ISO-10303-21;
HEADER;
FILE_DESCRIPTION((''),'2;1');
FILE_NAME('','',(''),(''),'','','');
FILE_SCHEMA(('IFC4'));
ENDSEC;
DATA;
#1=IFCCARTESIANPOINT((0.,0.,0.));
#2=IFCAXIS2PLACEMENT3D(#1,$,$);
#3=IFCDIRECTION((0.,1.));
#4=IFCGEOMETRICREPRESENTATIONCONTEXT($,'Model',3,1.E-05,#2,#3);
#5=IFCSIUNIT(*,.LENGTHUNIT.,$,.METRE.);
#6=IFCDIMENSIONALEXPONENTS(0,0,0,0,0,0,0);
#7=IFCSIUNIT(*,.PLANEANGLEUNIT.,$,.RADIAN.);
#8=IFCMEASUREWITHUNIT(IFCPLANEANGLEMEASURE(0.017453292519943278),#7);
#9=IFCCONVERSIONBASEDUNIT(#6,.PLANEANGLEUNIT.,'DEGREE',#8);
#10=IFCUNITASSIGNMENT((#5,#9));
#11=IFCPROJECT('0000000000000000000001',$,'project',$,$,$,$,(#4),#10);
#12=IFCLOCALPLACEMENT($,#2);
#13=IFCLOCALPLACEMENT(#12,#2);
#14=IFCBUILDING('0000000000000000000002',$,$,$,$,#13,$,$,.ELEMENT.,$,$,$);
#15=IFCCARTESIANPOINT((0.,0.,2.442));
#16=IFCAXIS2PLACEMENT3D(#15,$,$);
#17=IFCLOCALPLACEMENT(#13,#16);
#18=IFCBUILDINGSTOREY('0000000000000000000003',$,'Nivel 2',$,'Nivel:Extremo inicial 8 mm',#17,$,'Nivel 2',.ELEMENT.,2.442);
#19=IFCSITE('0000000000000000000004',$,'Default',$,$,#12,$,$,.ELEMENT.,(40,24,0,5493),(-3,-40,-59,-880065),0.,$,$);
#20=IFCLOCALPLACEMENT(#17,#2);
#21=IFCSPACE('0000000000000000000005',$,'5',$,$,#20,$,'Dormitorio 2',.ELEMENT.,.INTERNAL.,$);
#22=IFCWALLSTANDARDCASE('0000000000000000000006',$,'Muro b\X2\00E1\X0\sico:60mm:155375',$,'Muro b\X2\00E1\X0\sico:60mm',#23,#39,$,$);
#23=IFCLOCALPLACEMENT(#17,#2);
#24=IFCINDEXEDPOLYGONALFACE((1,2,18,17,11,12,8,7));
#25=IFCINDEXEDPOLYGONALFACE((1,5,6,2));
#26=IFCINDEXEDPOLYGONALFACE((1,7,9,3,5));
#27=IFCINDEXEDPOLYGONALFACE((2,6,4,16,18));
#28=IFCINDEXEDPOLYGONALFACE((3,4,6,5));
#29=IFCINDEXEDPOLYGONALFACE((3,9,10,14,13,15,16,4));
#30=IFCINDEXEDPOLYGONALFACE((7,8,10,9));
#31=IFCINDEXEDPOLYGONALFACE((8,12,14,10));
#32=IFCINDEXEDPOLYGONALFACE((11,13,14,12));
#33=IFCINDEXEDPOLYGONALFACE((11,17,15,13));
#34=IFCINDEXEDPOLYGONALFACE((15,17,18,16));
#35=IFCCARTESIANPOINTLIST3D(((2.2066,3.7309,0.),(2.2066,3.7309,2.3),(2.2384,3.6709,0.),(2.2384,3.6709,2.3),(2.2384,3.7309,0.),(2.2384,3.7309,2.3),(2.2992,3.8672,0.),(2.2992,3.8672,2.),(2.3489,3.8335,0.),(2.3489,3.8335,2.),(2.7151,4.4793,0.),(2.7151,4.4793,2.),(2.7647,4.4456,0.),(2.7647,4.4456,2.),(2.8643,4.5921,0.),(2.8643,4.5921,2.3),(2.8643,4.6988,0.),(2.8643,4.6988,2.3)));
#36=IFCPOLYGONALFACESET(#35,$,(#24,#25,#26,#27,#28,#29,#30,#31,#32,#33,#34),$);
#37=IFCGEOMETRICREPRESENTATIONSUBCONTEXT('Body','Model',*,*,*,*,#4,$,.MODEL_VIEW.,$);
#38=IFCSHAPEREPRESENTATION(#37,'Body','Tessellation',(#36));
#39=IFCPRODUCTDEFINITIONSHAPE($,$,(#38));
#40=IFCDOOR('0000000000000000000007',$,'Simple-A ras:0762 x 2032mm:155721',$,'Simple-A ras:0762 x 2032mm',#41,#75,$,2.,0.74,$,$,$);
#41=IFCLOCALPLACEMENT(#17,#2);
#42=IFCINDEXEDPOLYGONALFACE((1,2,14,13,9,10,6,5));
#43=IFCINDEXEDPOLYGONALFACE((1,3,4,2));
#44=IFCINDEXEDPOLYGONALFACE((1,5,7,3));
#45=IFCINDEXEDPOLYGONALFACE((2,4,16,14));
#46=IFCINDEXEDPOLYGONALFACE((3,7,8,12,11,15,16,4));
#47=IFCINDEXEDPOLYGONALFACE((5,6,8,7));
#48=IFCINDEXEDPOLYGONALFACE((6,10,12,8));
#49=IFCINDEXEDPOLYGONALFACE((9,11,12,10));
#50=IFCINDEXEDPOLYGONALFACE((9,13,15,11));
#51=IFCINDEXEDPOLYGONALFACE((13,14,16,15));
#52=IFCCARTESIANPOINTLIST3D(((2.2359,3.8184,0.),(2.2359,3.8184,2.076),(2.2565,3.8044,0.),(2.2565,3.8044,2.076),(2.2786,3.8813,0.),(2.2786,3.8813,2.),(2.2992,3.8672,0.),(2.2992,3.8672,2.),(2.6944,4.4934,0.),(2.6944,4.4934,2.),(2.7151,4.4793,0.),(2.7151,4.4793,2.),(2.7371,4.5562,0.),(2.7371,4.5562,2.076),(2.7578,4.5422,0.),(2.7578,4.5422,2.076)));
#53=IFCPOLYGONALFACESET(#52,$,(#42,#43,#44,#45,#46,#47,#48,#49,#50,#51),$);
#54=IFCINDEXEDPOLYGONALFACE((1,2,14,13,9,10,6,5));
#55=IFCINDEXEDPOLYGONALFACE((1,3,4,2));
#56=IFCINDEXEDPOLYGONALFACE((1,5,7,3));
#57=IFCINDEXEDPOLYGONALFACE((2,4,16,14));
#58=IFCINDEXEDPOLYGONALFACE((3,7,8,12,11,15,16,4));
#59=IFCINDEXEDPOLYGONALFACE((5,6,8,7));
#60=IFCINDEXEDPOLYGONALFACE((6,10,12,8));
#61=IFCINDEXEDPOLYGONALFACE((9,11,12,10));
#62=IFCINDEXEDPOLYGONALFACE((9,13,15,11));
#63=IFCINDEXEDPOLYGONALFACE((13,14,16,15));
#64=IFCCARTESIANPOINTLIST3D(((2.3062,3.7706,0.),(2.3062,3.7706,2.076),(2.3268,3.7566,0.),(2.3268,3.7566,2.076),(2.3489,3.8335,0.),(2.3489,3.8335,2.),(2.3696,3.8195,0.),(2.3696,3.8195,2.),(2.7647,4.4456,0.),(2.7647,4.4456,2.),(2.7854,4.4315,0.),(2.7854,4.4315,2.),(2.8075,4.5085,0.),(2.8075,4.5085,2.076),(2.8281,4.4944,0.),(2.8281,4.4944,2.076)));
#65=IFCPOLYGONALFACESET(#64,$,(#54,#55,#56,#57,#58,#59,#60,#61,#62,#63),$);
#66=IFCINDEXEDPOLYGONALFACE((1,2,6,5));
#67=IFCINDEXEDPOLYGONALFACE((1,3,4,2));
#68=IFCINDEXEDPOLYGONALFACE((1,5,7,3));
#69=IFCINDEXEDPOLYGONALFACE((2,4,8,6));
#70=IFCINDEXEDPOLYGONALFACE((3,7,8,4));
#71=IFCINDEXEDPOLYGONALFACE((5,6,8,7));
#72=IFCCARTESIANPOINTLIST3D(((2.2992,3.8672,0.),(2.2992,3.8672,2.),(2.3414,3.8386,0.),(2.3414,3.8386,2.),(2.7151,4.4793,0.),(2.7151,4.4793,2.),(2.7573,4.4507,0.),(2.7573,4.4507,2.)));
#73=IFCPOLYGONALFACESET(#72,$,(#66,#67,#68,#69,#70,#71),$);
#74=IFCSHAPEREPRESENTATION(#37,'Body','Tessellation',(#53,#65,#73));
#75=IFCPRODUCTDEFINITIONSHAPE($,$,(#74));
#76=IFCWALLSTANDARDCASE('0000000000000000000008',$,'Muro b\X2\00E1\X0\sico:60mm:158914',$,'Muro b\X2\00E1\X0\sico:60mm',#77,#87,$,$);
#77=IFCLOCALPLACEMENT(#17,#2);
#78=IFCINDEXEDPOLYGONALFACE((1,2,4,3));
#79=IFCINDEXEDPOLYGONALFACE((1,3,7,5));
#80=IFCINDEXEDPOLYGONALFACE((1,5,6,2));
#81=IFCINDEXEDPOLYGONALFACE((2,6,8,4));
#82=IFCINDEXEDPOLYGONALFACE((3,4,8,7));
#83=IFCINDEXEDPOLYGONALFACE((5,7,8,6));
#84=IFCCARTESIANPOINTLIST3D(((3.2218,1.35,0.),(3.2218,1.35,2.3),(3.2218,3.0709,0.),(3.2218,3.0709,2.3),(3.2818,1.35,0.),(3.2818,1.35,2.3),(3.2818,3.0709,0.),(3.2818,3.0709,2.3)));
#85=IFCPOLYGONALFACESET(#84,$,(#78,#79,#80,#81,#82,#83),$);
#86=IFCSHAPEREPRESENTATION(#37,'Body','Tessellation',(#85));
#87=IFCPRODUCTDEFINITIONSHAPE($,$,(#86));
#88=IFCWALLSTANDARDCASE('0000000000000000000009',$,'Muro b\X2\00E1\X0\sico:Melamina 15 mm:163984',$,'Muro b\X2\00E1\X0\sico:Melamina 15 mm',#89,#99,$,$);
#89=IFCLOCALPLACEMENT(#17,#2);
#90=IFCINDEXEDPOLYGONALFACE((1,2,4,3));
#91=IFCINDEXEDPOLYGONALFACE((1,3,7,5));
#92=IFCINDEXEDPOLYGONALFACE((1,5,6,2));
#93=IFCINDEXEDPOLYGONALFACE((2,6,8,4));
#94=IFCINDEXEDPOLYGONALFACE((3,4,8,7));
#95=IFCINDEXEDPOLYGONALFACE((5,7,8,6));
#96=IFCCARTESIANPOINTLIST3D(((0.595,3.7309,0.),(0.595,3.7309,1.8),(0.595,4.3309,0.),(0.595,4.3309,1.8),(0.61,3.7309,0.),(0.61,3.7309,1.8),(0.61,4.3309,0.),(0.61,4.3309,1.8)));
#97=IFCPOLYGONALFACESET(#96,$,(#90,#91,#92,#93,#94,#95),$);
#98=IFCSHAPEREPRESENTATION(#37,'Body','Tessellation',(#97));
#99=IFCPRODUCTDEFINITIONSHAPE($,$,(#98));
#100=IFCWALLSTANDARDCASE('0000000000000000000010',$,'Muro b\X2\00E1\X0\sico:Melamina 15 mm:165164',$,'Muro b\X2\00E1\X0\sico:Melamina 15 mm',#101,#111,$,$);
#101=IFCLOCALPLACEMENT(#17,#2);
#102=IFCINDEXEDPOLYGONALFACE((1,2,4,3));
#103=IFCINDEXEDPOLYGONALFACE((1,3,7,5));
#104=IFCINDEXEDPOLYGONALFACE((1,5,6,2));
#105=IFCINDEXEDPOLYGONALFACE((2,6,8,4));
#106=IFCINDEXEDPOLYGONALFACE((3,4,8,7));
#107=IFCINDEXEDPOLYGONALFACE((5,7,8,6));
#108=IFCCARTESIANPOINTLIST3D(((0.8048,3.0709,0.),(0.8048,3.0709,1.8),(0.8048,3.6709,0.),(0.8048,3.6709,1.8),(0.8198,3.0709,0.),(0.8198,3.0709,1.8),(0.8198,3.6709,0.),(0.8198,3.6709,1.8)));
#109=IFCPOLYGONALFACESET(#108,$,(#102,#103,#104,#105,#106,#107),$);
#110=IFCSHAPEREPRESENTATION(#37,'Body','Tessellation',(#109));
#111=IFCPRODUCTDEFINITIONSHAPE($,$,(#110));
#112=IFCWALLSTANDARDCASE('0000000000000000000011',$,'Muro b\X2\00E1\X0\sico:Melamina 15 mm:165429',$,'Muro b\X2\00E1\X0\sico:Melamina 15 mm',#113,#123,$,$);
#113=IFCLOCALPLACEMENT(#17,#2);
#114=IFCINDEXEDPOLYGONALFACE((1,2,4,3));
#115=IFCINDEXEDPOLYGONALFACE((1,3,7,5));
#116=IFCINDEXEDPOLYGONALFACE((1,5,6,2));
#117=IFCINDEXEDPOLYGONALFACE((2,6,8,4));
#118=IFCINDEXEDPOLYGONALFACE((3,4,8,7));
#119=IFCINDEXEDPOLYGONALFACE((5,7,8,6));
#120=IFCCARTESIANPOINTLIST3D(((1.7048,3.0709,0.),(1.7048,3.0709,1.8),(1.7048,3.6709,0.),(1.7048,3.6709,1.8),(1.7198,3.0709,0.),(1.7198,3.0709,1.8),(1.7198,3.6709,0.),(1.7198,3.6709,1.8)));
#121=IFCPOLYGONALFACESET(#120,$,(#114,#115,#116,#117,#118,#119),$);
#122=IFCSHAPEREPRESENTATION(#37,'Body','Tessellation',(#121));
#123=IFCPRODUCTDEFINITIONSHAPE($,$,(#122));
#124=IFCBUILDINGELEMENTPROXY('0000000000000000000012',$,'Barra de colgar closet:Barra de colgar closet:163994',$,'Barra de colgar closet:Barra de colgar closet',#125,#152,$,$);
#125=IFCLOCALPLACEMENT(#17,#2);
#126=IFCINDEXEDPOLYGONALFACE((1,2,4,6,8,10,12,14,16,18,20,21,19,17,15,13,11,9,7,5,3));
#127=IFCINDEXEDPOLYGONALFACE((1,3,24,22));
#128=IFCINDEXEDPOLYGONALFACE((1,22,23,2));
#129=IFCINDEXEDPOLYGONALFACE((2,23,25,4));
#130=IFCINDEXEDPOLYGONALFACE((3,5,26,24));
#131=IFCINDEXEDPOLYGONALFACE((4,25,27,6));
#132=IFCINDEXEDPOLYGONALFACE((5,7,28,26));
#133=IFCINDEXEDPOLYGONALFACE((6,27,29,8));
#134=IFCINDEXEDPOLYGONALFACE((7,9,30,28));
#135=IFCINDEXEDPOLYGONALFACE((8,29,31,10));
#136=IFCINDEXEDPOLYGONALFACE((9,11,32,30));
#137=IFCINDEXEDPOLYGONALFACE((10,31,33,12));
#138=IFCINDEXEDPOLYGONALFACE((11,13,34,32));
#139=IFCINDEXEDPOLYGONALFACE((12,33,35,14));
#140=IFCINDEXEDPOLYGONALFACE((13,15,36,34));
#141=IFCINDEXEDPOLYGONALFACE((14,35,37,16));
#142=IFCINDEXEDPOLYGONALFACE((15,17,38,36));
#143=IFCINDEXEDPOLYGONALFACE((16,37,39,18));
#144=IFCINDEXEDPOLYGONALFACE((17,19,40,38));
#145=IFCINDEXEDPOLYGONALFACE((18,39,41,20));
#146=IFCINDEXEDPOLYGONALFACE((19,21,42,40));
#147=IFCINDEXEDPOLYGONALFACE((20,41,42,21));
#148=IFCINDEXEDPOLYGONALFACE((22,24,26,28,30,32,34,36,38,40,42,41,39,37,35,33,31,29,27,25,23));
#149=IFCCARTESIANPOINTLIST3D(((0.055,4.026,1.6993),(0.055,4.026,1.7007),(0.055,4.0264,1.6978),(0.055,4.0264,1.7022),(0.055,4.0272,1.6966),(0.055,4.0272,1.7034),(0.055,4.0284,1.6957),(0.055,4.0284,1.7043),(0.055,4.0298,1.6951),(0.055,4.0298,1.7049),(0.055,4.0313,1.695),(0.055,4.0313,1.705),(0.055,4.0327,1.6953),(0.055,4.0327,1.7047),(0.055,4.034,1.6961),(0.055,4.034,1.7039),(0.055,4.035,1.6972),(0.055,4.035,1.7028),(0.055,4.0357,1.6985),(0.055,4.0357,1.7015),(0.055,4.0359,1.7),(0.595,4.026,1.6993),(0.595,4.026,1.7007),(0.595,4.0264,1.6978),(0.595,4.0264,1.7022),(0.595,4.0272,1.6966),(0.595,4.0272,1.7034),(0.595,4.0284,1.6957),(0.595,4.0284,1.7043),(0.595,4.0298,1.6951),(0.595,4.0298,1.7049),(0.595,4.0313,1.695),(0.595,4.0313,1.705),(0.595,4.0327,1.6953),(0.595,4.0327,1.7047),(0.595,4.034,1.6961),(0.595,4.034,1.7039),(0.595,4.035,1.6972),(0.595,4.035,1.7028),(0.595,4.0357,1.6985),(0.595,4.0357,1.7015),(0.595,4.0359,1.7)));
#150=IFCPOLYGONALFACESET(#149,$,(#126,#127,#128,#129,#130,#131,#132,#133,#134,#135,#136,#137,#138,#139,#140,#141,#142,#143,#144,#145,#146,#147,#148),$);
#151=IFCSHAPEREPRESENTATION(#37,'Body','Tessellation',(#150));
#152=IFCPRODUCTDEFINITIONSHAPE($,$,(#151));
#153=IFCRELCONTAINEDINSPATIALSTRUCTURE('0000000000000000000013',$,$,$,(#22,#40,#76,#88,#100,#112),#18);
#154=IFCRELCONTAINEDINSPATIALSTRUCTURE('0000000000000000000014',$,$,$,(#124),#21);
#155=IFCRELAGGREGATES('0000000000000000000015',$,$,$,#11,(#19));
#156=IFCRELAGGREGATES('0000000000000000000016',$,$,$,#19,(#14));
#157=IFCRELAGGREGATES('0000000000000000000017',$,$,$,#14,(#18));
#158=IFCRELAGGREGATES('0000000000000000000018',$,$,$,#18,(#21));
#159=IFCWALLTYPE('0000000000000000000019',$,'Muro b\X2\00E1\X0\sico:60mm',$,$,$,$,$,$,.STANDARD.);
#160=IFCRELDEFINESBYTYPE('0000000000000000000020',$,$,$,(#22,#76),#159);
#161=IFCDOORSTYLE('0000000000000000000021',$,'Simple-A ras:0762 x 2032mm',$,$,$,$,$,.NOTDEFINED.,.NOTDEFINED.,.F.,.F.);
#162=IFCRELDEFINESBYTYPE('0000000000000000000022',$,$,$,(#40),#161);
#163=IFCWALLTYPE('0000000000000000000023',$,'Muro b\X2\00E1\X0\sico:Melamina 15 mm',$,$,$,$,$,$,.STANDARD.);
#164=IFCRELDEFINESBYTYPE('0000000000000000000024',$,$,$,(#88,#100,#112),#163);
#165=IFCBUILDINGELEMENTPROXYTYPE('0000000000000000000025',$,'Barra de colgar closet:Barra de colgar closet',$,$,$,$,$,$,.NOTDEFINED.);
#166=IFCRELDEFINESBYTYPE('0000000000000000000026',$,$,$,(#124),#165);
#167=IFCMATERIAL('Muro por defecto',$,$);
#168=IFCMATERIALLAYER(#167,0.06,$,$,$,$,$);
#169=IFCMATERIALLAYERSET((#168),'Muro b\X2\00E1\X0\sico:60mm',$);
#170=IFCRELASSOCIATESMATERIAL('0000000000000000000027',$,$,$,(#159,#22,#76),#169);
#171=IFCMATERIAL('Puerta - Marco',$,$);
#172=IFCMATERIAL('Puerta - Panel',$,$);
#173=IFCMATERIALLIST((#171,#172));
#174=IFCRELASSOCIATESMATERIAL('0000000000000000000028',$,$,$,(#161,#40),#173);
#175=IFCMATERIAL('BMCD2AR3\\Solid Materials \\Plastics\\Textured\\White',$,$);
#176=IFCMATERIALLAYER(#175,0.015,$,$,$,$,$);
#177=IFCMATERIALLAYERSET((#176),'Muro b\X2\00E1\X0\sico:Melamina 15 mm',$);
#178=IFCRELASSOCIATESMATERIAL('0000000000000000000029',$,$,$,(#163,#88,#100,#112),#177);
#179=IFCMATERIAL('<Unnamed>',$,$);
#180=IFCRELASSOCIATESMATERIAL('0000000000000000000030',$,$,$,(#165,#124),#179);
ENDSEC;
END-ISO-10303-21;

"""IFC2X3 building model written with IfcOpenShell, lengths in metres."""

from ifc_helpers import new_model, entity, si_unit, converted_unit, direction, frame, frame_2d, origin, origin_2d_with_axis, place, context, subcontext, project, spatial, polyline, rectangle, circle, outline, extrude, source, transform, mapped, material, material_list, layer, layer_set, layer_usage, type_object, type_shapes, element, fill, save


model = new_model("IFC2X3")

# Units and contexts
model_context = context("Model", 3, precision=1e-05, world=origin(), true_north=direction((0.0, 1.0)))
body_context = subcontext(model_context, "Body", "Model", "MODEL_VIEW")
ifc_project = project(units=[si_unit("LENGTHUNIT", "METRE"), converted_unit("PLANEANGLEUNIT", "DEGREE", entity("IfcPlaneAngleMeasure", 0.017453292519943278), si_unit("PLANEANGLEUNIT", "RADIAN"), dimensions=[0, 0, 0, 0, 0, 0, 0])], contexts=[model_context])

# Site, building, storey
site_placement = place(None, origin())
site = spatial("IfcSite", under=ifc_project, at=site_placement, Name="Default", CompositionType="ELEMENT", RefLatitude=(40, 24, 0, 5493), RefLongitude=(-3, -40, -59, -880065), RefElevation=0.0)
building_placement = place(site_placement, origin())
building = spatial("IfcBuilding", under=site, at=building_placement, CompositionType="ELEMENT")
storey_placement = place(building_placement, frame((0.0, 0.0, 2.442)))
storey = spatial("IfcBuildingStorey", under=building, at=storey_placement, Name="Nivel 2", ObjectType="Nivel:Extremo inicial 8 mm", LongName="Nivel 2", CompositionType="ELEMENT", Elevation=2.442)

# Shared definitions
ifc_material_1 = material(Name="BMCD2AR3\\Solid Materials \\Plastics\\Textured\\White")

# Shared definitions
ifc_material_2 = material(Name="Muro por defecto")

# Shared definitions
ifc_material_3 = material(Name="Puerta - Marco")
ifc_material_4 = material(Name="Puerta - Panel")
ifc_material_list_1 = material_list([ifc_material_3, ifc_material_4])

# Shared definitions
ifc_layer_1 = layer(ifc_material_2, 0.06)
ifc_layer_set_1 = layer_set([ifc_layer_1], Name="Muro básico:60mm")
wall_type_1 = type_object("IfcWallType", Name="Muro básico:60mm", PredefinedType="STANDARD", material=ifc_layer_set_1)

# Wall, opening, door
door_style_1 = type_object("IfcDoorStyle", Name="Simple-A ras:0762 x 2032mm", ConstructionType="NOTDEFINED", OperationType="NOTDEFINED", ParameterTakesPrecedence=False, Sizeable=False, material=ifc_material_list_1)
shared_shape_1 = source(origin(), body_context, "Body", "SweptSolid", [
    extrude(outline(polyline([(-0.446, -1.057), (0.446, -1.057), (0.446, 1.019), (0.37, 1.019), (0.37, -0.981), (-0.37, -0.981), (-0.37, 1.019), (-0.446, 1.019), (-0.446, -1.057)])), frame((0.37, 0.085, 1.019), z_axis=(0.0, -1.0, 0.0), x_axis=(-1.0, 0.0, 0.0)), (0.0, 0.0, 1.0), 0.025),
    extrude(outline(polyline([(-1.057, -0.446), (1.019, -0.446), (1.019, -0.37), (-0.981, -0.37), (-0.981, 0.37), (1.019, 0.37), (1.019, 0.446), (-1.057, 0.446), (-1.057, -0.446)])), frame((0.37, 0.0, 1.019), z_axis=(0.0, -1.0, 0.0), x_axis=(0.0, 0.0, -1.0)), (0.0, 0.0, 1.0), 0.025),
    extrude(rectangle(XDim=0.74, YDim=0.051, at=origin_2d_with_axis()), frame((0.37, 0.0345, 0.0)), (0.0, 0.0, 1.0), 2.0),
])
type_shapes(door_style_1, [shared_shape_1])
ifc_layer_usage_1 = layer_usage(ifc_layer_set_1, "AXIS2", "NEGATIVE", 0.03)
wall_1_placement = place(storey_placement, frame((2.2136, 3.6878, 0.0), z_axis=(0.0, 0.0, 1.0), x_axis=(0.561981, 0.82715, 0.0)))
wall_1 = element("IfcWallStandardCase", 1, at=wall_1_placement, inside=storey, type_object=wall_type_1, material=ifc_layer_usage_1, Name="Muro básico:60mm:155375", ObjectType="Muro básico:60mm", context=body_context, shape_type="SweptSolid", body=[
    extrude(outline(polyline([(0.0, -0.03), (1.1127, -0.03), (1.1137, -0.03), (1.1817, 0.0162), (1.202, 0.03), (1.0543, 0.03), (0.0318, 0.03), (0.0496, 0.0037), (0.0, -0.03)])), origin(), (0.0, 0.0, 1.0), 2.3),
])
opening_1_placement = place(wall_1_placement, frame((0.1966, -0.03, 0.0)))
opening_1 = element("IfcOpeningElement", 2, at=opening_1_placement, cuts=wall_1, ObjectType="Opening", context=body_context, shape_type="SweptSolid", body=[
    extrude(rectangle(XDim=0.74, YDim=2.0, at=frame_2d((1.0, 0.37), x_axis=(0.0, -1.0))), frame((0.0, 0.0, 0.0), z_axis=(0.0, 1.0, 0.0), x_axis=(0.0, 0.0, 1.0)), (0.0, 0.0, 1.0), 0.06),
])
door_1_placement = place(opening_1_placement, origin())
door_1 = element("IfcDoor", 3, at=door_1_placement, inside=storey, type_object=door_style_1, material=ifc_material_list_1, Name="Simple-A ras:0762 x 2032mm:155721", ObjectType="Simple-A ras:0762 x 2032mm", OverallHeight=2.0, OverallWidth=0.74, context=body_context, shape_type="MappedRepresentation", body=[
    mapped(shared_shape_1, transform((0.0, 0.0, 0.0), scale=1.0)),
])
fill(opening_1, door_1)

# Walls
ifc_layer_usage_2 = layer_usage(ifc_layer_set_1, "AXIS2", "NEGATIVE", 0.03)
wall_2_placement = place(storey_placement, frame((3.2518, 3.0709, 0.0), z_axis=(0.0, 0.0, 1.0), x_axis=(0.0, -1.0, 0.0)))
element("IfcWallStandardCase", 4, at=wall_2_placement, inside=storey, type_object=wall_type_1, material=ifc_layer_usage_2, Name="Muro básico:60mm:158914", ObjectType="Muro básico:60mm", context=body_context, shape_type="SweptSolid", body=[
    extrude(rectangle(XDim=1.7209, YDim=0.06, at=frame_2d((0.8605, 0.0), x_axis=(-1.0, 0.0))), origin(), (0.0, 0.0, 1.0), 2.3),
])
ifc_layer_2 = layer(ifc_material_1, 0.015)
ifc_layer_set_2 = layer_set([ifc_layer_2], Name="Muro básico:Melamina 15 mm")
ifc_layer_usage_3 = layer_usage(ifc_layer_set_2, "AXIS2", "NEGATIVE", 0.0075)
wall_type_2 = type_object("IfcWallType", Name="Muro básico:Melamina 15 mm", PredefinedType="STANDARD", material=ifc_layer_set_2)
wall_3_placement = place(storey_placement, frame((0.6025, 4.3309, 0.0), z_axis=(0.0, 0.0, 1.0), x_axis=(0.0, -1.0, 0.0)))
element("IfcWallStandardCase", 5, at=wall_3_placement, inside=storey, type_object=wall_type_2, material=ifc_layer_usage_3, Name="Muro básico:Melamina 15 mm:163984", ObjectType="Muro básico:Melamina 15 mm", context=body_context, shape_type="SweptSolid", body=[
    extrude(rectangle(XDim=0.6, YDim=0.015, at=frame_2d((0.3, 0.0), x_axis=(-1.0, 0.0))), origin(), (0.0, 0.0, 1.0), 1.8),
])
ifc_layer_usage_4 = layer_usage(ifc_layer_set_2, "AXIS2", "NEGATIVE", 0.0075)
wall_4_placement = place(storey_placement, frame((0.8123, 3.6709, 0.0), z_axis=(0.0, 0.0, 1.0), x_axis=(0.0, -1.0, 0.0)))
element("IfcWallStandardCase", 6, at=wall_4_placement, inside=storey, type_object=wall_type_2, material=ifc_layer_usage_4, Name="Muro básico:Melamina 15 mm:165164", ObjectType="Muro básico:Melamina 15 mm", context=body_context, shape_type="SweptSolid", body=[
    extrude(rectangle(XDim=0.6, YDim=0.015, at=frame_2d((0.3, 0.0), x_axis=(-1.0, 0.0))), origin(), (0.0, 0.0, 1.0), 1.8),
])
ifc_layer_usage_5 = layer_usage(ifc_layer_set_2, "AXIS2", "NEGATIVE", 0.0075)
wall_5_placement = place(storey_placement, frame((1.7123, 3.6709, 0.0), z_axis=(0.0, 0.0, 1.0), x_axis=(0.0, -1.0, 0.0)))
element("IfcWallStandardCase", 7, at=wall_5_placement, inside=storey, type_object=wall_type_2, material=ifc_layer_usage_5, Name="Muro básico:Melamina 15 mm:165429", ObjectType="Muro básico:Melamina 15 mm", context=body_context, shape_type="SweptSolid", body=[
    extrude(rectangle(XDim=0.6, YDim=0.015, at=frame_2d((0.3, 0.0), x_axis=(-1.0, 0.0))), origin(), (0.0, 0.0, 1.0), 1.8),
])

# Shared definitions
space_1_placement = place(storey_placement, origin())
space_1 = spatial("IfcSpace", under=storey, at=space_1_placement, Name="5", LongName="Dormitorio 2", CompositionType="ELEMENT", InteriorOrExteriorSpace="INTERNAL")

# Building element proxy
ifc_material_5 = material(Name="<Unnamed>")
building_element_proxy_type_1 = type_object("IfcBuildingElementProxyType", Name="Barra de colgar closet:Barra de colgar closet", PredefinedType="NOTDEFINED", material=ifc_material_5)
shared_shape_2 = source(origin(), body_context, "Body", "SweptSolid", [
    extrude(circle(Radius=0.005, at=frame_2d((0.0, 0.0), x_axis=(1.0, 0.0))), frame((-0.27, 0.0, 0.0), z_axis=(1.0, 0.0, 0.0), x_axis=(0.0, 1.0, 0.0)), (0.0, 0.0, 1.0), 0.54),
])
type_shapes(building_element_proxy_type_1, [shared_shape_2])
proxy_1_placement = place(space_1_placement, frame((0.325, 4.0309, 1.7)))
element("IfcBuildingElementProxy", 8, at=proxy_1_placement, inside=space_1, type_object=building_element_proxy_type_1, material=ifc_material_5, Name="Barra de colgar closet:Barra de colgar closet:163994", ObjectType="Barra de colgar closet:Barra de colgar closet", context=body_context, shape_type="MappedRepresentation", body=[
    mapped(shared_shape_2, transform((0.0, 0.0, 0.0), scale=1.0)),
])

save(model, "model.ifc")
